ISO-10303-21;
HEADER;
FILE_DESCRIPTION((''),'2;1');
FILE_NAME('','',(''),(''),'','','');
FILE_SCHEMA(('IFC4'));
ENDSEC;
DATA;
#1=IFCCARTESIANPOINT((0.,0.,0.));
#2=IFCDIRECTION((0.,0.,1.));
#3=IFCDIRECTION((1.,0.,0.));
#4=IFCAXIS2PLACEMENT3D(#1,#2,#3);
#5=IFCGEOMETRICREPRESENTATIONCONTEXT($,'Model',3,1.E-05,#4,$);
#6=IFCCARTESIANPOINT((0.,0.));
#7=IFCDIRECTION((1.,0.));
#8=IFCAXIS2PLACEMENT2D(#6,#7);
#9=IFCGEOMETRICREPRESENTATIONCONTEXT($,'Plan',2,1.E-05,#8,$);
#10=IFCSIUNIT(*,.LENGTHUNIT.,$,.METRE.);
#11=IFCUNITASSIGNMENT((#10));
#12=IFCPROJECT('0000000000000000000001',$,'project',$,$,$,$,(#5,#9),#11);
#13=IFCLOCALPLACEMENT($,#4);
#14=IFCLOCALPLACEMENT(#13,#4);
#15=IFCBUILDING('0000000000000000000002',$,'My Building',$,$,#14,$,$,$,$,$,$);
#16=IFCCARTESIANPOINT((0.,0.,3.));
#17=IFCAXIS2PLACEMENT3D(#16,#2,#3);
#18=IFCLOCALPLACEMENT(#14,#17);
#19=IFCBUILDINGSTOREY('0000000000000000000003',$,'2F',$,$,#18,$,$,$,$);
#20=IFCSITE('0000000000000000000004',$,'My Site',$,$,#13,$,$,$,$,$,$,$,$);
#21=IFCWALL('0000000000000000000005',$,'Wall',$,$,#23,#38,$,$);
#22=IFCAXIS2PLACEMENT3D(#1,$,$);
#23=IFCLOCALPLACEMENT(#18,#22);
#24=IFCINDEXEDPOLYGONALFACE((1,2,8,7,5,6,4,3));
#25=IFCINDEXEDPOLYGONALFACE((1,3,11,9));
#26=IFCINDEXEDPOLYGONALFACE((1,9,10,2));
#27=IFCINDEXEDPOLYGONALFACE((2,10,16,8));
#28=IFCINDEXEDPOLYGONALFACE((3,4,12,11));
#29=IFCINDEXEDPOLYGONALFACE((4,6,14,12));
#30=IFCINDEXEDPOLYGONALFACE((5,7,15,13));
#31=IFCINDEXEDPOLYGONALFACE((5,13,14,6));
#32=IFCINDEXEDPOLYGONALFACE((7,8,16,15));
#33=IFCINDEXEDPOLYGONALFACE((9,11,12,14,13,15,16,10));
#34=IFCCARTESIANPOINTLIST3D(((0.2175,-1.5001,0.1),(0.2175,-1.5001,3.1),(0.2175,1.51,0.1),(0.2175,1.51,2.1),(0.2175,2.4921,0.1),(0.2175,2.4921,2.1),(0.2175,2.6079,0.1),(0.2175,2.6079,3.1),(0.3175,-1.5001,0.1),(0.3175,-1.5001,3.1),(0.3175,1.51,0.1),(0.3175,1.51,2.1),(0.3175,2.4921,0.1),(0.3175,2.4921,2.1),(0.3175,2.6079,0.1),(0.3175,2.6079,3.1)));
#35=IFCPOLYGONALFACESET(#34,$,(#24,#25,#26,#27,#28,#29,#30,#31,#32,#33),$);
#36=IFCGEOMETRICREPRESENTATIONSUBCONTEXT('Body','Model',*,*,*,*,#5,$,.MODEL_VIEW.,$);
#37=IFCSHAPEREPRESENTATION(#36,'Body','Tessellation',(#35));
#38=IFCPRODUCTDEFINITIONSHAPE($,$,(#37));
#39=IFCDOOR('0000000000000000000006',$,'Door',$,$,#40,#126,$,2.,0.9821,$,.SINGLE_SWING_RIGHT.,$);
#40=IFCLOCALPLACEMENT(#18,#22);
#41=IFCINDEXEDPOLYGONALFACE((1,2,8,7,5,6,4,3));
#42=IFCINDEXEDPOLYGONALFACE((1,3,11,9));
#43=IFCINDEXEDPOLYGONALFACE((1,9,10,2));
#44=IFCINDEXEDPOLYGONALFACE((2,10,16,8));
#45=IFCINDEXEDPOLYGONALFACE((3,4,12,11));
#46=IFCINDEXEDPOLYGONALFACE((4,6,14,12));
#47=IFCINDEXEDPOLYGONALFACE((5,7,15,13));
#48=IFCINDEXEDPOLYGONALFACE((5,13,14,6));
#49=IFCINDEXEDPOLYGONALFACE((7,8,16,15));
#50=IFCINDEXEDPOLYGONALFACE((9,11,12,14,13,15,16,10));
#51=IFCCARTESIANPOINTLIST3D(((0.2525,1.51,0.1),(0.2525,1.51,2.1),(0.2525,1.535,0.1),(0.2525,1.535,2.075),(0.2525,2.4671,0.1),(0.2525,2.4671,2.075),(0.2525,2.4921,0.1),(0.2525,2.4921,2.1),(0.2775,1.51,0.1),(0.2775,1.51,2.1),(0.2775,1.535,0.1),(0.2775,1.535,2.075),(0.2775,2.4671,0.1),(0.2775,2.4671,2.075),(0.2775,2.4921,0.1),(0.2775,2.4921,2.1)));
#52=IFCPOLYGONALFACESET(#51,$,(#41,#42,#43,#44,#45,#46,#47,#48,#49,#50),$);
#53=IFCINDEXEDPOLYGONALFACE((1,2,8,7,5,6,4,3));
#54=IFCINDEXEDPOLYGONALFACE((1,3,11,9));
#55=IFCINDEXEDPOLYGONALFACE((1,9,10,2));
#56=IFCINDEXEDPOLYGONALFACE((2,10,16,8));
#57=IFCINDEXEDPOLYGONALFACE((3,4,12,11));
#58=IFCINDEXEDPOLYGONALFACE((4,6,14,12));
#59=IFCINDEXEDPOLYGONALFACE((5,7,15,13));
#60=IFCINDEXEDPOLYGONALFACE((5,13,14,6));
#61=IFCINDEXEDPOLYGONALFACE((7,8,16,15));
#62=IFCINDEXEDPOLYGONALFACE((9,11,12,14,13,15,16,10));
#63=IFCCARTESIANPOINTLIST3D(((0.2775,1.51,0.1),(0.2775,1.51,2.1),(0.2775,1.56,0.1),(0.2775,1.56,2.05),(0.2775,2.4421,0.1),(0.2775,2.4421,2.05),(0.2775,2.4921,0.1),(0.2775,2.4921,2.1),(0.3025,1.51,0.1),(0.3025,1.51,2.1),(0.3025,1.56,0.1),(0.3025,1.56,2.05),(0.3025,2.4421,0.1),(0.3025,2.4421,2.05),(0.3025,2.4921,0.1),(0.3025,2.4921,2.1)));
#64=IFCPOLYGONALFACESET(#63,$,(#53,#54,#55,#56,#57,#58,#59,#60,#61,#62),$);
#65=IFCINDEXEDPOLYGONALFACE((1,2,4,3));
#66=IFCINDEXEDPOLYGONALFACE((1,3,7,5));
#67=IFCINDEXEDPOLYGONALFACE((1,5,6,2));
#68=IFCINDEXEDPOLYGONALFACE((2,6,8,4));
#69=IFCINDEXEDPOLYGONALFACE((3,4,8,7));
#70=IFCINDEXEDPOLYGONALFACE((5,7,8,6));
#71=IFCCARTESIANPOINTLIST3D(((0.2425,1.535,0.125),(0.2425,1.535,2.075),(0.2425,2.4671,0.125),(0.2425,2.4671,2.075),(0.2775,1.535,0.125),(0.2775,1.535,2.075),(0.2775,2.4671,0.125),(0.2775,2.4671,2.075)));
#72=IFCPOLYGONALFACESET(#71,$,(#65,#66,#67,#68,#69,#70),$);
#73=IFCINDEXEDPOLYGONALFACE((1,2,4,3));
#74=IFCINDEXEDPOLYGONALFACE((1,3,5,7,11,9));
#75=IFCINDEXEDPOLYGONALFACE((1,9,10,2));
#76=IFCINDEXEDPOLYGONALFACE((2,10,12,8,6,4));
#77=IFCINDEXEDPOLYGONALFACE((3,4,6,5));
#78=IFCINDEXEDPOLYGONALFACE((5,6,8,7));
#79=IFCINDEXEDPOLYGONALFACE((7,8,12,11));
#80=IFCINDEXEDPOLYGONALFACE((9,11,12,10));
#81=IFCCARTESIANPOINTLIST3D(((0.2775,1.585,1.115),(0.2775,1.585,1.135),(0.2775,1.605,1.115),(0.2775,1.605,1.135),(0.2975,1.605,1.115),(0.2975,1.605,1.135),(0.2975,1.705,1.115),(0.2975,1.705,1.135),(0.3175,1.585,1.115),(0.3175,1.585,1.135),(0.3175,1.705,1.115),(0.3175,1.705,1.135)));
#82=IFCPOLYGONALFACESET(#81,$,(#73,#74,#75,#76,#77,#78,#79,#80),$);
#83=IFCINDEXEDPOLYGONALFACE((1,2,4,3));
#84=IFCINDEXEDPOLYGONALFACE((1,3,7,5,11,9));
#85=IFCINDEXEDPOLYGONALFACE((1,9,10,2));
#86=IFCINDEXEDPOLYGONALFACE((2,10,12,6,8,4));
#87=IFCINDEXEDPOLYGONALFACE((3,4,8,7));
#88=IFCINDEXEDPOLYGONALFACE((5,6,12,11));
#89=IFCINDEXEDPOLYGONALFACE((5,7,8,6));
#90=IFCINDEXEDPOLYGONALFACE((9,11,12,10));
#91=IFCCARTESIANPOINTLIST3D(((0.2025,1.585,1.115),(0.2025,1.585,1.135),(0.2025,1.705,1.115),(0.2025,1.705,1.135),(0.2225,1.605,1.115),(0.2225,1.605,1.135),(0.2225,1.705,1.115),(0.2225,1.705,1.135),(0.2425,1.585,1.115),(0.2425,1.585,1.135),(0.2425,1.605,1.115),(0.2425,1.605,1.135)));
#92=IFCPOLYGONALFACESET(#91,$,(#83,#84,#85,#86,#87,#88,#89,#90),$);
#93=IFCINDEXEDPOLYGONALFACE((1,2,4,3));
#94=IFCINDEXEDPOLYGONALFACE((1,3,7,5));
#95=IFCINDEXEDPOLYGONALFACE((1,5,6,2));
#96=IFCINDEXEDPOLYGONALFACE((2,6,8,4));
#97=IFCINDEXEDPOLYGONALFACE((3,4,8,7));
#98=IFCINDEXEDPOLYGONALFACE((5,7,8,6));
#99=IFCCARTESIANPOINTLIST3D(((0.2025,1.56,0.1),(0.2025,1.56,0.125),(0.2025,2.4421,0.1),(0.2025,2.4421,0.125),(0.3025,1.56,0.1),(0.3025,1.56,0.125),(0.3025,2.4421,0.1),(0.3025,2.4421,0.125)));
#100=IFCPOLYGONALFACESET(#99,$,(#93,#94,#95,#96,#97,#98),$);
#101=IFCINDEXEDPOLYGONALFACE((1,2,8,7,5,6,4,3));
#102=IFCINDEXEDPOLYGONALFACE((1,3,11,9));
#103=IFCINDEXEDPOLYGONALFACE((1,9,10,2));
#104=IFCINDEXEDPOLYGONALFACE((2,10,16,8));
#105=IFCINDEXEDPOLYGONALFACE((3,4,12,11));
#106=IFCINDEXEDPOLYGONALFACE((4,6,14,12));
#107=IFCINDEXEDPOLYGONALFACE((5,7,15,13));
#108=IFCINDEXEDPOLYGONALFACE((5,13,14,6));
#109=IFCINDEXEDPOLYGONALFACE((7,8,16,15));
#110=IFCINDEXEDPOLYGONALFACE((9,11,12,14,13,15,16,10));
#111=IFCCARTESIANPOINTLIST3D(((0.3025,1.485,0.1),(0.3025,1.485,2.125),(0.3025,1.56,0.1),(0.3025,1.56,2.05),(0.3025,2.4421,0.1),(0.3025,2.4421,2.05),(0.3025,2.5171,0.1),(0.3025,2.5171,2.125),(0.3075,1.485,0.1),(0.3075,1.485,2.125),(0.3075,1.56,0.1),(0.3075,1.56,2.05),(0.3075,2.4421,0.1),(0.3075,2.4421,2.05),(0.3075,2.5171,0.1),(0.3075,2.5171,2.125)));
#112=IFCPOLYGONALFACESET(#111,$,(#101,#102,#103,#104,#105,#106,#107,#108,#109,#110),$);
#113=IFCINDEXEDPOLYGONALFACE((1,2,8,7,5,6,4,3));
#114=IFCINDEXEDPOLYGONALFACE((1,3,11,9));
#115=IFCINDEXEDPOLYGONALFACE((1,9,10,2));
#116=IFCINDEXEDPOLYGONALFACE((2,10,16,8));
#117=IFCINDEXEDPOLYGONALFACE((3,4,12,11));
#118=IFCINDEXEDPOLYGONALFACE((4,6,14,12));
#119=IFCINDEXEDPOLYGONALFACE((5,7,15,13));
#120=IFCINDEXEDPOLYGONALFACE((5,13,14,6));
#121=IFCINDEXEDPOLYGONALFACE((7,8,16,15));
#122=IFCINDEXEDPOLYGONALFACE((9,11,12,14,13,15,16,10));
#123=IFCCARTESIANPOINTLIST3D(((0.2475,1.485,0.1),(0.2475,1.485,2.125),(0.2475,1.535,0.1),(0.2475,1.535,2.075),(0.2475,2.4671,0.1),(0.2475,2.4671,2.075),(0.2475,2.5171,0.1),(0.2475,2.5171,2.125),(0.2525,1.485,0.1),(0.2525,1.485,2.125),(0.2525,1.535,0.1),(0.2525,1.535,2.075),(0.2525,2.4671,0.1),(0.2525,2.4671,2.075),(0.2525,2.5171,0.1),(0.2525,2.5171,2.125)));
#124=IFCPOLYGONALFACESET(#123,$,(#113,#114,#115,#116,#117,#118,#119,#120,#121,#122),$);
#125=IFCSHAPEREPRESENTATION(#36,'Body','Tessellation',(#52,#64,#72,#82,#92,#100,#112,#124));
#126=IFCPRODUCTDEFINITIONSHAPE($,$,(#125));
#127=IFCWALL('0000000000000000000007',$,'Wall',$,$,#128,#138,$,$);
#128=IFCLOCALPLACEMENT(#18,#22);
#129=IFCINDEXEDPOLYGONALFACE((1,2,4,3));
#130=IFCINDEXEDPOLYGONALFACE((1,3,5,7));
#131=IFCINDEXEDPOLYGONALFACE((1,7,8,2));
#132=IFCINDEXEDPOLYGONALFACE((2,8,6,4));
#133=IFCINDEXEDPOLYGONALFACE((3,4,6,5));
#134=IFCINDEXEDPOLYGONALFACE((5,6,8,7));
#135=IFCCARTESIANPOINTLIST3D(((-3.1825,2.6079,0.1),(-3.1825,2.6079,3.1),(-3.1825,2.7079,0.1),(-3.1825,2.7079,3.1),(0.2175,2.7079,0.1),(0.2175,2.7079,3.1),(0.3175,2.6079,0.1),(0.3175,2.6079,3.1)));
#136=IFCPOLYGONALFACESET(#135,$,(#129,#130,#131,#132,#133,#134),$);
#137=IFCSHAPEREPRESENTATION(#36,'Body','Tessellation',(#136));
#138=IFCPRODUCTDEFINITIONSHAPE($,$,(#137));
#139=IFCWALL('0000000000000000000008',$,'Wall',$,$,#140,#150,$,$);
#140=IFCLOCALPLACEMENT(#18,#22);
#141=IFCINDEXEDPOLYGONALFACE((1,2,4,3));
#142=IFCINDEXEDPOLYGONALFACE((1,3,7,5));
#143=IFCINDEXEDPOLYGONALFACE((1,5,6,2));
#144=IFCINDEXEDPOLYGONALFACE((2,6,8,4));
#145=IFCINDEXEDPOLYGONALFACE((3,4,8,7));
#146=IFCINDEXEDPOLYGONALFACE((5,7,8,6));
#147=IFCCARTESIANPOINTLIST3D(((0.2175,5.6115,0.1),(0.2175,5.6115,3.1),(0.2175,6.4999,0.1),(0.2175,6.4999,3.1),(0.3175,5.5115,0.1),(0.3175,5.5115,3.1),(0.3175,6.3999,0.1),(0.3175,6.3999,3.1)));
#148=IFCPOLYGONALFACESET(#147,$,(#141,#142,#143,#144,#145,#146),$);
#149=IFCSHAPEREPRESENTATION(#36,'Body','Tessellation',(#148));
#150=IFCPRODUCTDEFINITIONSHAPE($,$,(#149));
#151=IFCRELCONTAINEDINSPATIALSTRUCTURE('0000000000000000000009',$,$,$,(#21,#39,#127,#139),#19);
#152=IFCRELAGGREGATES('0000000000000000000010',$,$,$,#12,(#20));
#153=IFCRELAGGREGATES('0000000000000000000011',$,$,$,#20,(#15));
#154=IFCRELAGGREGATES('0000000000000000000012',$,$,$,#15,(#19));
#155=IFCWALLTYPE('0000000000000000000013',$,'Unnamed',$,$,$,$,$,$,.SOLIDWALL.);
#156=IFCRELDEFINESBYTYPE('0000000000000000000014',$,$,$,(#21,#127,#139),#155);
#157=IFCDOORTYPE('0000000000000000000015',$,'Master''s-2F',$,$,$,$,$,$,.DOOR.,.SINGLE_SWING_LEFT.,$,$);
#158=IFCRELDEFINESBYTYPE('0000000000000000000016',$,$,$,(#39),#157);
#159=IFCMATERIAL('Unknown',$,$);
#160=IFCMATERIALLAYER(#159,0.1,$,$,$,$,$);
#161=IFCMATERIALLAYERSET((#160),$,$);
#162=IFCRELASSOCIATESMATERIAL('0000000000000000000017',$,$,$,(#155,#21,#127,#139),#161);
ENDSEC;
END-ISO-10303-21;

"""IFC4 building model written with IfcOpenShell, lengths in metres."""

from ifc_helpers import new_model, entity, si_unit, frame, origin_with_axes, origin_2d_with_axis, place, context, subcontext, project, spatial, line, indexed_curve, outline, extrude, shape, source, transform, mapped, material, layer, layer_set, layer_usage, type_object, type_shapes, element, fill, save


model = new_model("IFC4")

# Units and contexts
model_context = context("Model", 3, precision=1e-05, world=origin_with_axes())
plan_context = context("Plan", 2, precision=1e-05, world=origin_2d_with_axis())
body_context_1 = subcontext(model_context, "Body", "Model", "MODEL_VIEW")
body_context_2 = subcontext(plan_context, "Body", "Plan", "PLAN_VIEW")
ifc_project = project(units=[si_unit("LENGTHUNIT", "METRE")], contexts=[model_context, plan_context])

# Site, building, storey
site_placement = place(None, origin_with_axes())
site = spatial("IfcSite", under=ifc_project, at=site_placement, Name="My Site")
building_placement = place(site_placement, origin_with_axes())
building = spatial("IfcBuilding", under=site, at=building_placement, Name="My Building")
storey_placement = place(building_placement, frame((0.0, 0.0, 3.0), z_axis=(0.0, 0.0, 1.0), x_axis=(1.0, 0.0, 0.0)))
storey = spatial("IfcBuildingStorey", under=building, at=storey_placement, Name="2F")

# Shared definitions
ifc_material = material(Name="Unknown")

# Shared definitions
ifc_layer_1 = layer(ifc_material, 0.1)
ifc_layer_set_1 = layer_set([ifc_layer_1])
wall_type = type_object("IfcWallType", Name="Unnamed", PredefinedType="SOLIDWALL", material=ifc_layer_set_1)

# Wall, opening, door
ifc_layer_usage_1 = layer_usage(ifc_layer_set_1, "AXIS2", "POSITIVE", 0.0)
wall_1_placement = place(storey_placement, frame((0.2175, 2.7079, 0.1), z_axis=(0.0, 0.0, 1.0), x_axis=(0.0, -1.0, 0.0)))
wall_1 = element("IfcWall", 1, at=wall_1_placement, inside=storey, type_object=wall_type, material=ifc_layer_usage_1, Name="Wall", context=body_context_1, shape_type="SweptSolid", body=[
    extrude(outline(indexed_curve([(0.1, 0.0), (0.1, 0.1), (4.2079, 0.1), (4.2079, 0.0)], segments=[line(1, 2, 3, 4, 1)])), origin_with_axes(), (0.0, 0.0, 1.0), 3.0),
])
shared_shape_1 = source(origin_with_axes(), body_context_1, "Body", "SweptSolid", [
    extrude(outline(indexed_curve([(0.0, 0.0), (0.9821, 0.0), (0.9821, 2.0), (0.0, 2.0)], segments=[line(1, 2, 3, 4, 1)])), frame((0.0, -0.6, 0.0), z_axis=(0.0, -1.0, 0.0), x_axis=(1.0, 0.0, 0.0)), (0.0, 0.0, -1.0), 1.2),
])
opening_1_placement = place(wall_1_placement, frame((1.1978, 0.085, 0.0), z_axis=(0.0, 0.0, 1.0), x_axis=(-1.0, 0.0, 0.0)))
opening_1 = element("IfcOpeningElement", 2, at=opening_1_placement, cuts=wall_1, PredefinedType="OPENING", context=body_context_1, shape_type="MappedRepresentation", body=[
    mapped(shared_shape_1, transform((0.0, 0.0, 0.0), x_axis=(1.0, 0.0, 0.0), y_axis=(0.0, 1.0, 0.0), z_axis=(0.0, 0.0, 1.0), scale=1.0)),
])
door_type_1 = type_object("IfcDoorType", Name="Master's-2F", OperationType="SINGLE_SWING_LEFT", PredefinedType="DOOR")
shared_shape_2 = source(origin_with_axes(), body_context_1, "Body", "SweptSolid", [
    extrude(outline(indexed_curve([(0.0, 0.0), (0.0, 2.0), (0.9821, 2.0), (0.9821, 0.0), (0.9571, 0.0), (0.9571, 1.975), (0.025, 1.975), (0.025, 0.0)], segments=[line(1, 2, 3, 4, 5, 6, 7, 8, 1)])), frame((0.0, 0.025, 0.0), z_axis=(0.0, -1.0, 0.0), x_axis=(1.0, 0.0, 0.0)), (0.0, 0.0, -1.0), 0.025),
    extrude(outline(indexed_curve([(0.0, 0.0), (0.0, 2.0), (0.9821, 2.0), (0.9821, 0.0), (0.9321, 0.0), (0.9321, 1.95), (0.05, 1.95), (0.05, 0.0)], segments=[line(1, 2, 3, 4, 5, 6, 7, 8, 1)])), frame((0.0, 0.0, 0.0), z_axis=(0.0, -1.0, 0.0), x_axis=(1.0, 0.0, 0.0)), (0.0, 0.0, -1.0), 0.025),
    extrude(outline(indexed_curve([(0.0, 0.0), (0.9321, 0.0), (0.9321, 0.035), (0.0, 0.035)], segments=[line(1, 2, 3, 4, 1)])), frame((0.025, 0.025, 0.025), z_axis=(0.0, 0.0, 1.0), x_axis=(1.0, 0.0, 0.0)), (0.0, 0.0, 1.0), 1.95),
    extrude(outline(indexed_curve([(0.0, 0.0), (0.0, -0.04), (0.12, -0.04), (0.12, -0.02), (0.02, -0.02), (0.02, 0.0)], segments=[line(1, 2, 3, 4, 5, 6, 1)])), frame((0.075, 0.025, 1.015), z_axis=(0.0, 0.0, 1.0), x_axis=(1.0, 0.0, 0.0)), (0.0, 0.0, 1.0), 0.02),
    extrude(outline(indexed_curve([(0.0, 0.0), (0.0, 0.04), (0.12, 0.04), (0.12, 0.02), (0.02, 0.02), (0.02, 0.0)], segments=[line(1, 2, 3, 4, 5, 6, 1)])), frame((0.075, 0.06, 1.015), z_axis=(0.0, 0.0, 1.0), x_axis=(1.0, 0.0, 0.0)), (0.0, 0.0, 1.0), 0.02),
    extrude(outline(indexed_curve([(0.0, 0.0), (0.8821, 0.0), (0.8821, 0.1), (0.0, 0.1)], segments=[line(1, 2, 3, 4, 1)])), frame((0.05, 0.0, 0.0), z_axis=(0.0, 0.0, 1.0), x_axis=(1.0, 0.0, 0.0)), (0.0, 0.0, 1.0), 0.025),
    extrude(outline(indexed_curve([(0.0, 0.0), (0.0, 2.025), (1.0321, 2.025), (1.0321, 0.0), (0.9571, 0.0), (0.9571, 1.95), (0.075, 1.95), (0.075, 0.0)], segments=[line(1, 2, 3, 4, 5, 6, 7, 8, 1)])), frame((-0.025, -0.005, 0.0), z_axis=(0.0, -1.0, 0.0), x_axis=(1.0, 0.0, 0.0)), (0.0, 0.0, -1.0), 0.005),
    extrude(outline(indexed_curve([(0.0, 0.0), (0.0, 2.025), (1.0321, 2.025), (1.0321, 0.0), (0.9821, 0.0), (0.9821, 1.975), (0.05, 1.975), (0.05, 0.0)], segments=[line(1, 2, 3, 4, 5, 6, 7, 8, 1)])), frame((-0.025, 0.05, 0.0), z_axis=(0.0, -1.0, 0.0), x_axis=(1.0, 0.0, 0.0)), (0.0, 0.0, -1.0), 0.005),
])
shared_shape_3 = source(origin_with_axes(), body_context_2, "Body", "Curve2D", [
    entity("IfcIndexedPolyCurve", entity("IfcCartesianPointList2D", [[0.0, 0.0], [0.0, 0.05], [0.025, 0.05], [0.025, 0.025], [0.05, 0.025], [0.05, 0.0]]), [entity("IfcLineIndex", [1, 2, 3, 4, 5, 6, 1])]),
    entity("IfcIndexedPolyCurve", entity("IfcCartesianPointList2D", [[0.9821, 0.0], [0.9821, 0.05], [0.9571, 0.05], [0.9571, 0.025], [0.9321, 0.025], [0.9321, 0.0]]), [entity("IfcLineIndex", [1, 2, 3, 4, 5, 6, 1])]),
    entity("IfcTrimmedCurve", entity("IfcEllipse", entity("IfcAxis2Placement2D", entity("IfcCartesianPoint", [0.9221, 0.05]), entity("IfcDirection", [1.0, 0.0])), 0.8971, 0.9321), [entity("IfcCartesianPoint", [0.9221, 0.9821])], [entity("IfcCartesianPoint", [0.025, 0.05])], True, "CARTESIAN"),
    entity("IfcIndexedPolyCurve", entity("IfcCartesianPointList2D", [[0.9571, 0.05], [0.9221, 0.05], [0.9221, 0.9821], [0.9571, 0.9821]]), [entity("IfcLineIndex", [1, 2, 3, 4, 1])]),
])
type_shapes(door_type_1, [shared_shape_2, shared_shape_3])
door_1_placement = place(opening_1_placement, frame((0.0, 0.0, 0.0), z_axis=(0.0, 0.0, 1.0), x_axis=(1.0, 0.0, 0.0)))
door_1 = element("IfcDoor", 3, at=door_1_placement, inside=storey, type_object=door_type_1, Name="Door", OperationType="SINGLE_SWING_RIGHT", OverallHeight=2.0, OverallWidth=0.9821, shapes=[
    shape(body_context_1, "Body", "MappedRepresentation", [mapped(shared_shape_2, transform((0.0, 0.0, 0.0), x_axis=(1.0, 0.0, 0.0), y_axis=(0.0, 1.0, 0.0), z_axis=(0.0, 0.0, 1.0), scale=1.0))]),
    shape(body_context_2, "Body", "MappedRepresentation", [mapped(shared_shape_3, transform((0.0, 0.0, 0.0), x_axis=(1.0, 0.0, 0.0), y_axis=(0.0, 1.0, 0.0), z_axis=(0.0, 0.0, 1.0), scale=1.0))]),
])
fill(opening_1, door_1)

# Walls
ifc_layer_usage_2 = layer_usage(ifc_layer_set_1, "AXIS2", "POSITIVE", 0.0)
wall_2_placement = place(storey_placement, frame((0.3175, 2.7079, 0.1), z_axis=(0.0, 0.0, 1.0), x_axis=(-1.0, 0.0, 0.0)))
element("IfcWall", 4, at=wall_2_placement, inside=storey, type_object=wall_type, material=ifc_layer_usage_2, Name="Wall", context=body_context_1, shape_type="SweptSolid", body=[
    extrude(outline(indexed_curve([(0.1, 0.0), (0.0, 0.1), (3.5, 0.1), (3.5, 0.0)], segments=[line(1, 2, 3, 4, 1)])), origin_with_axes(), (0.0, 0.0, 1.0), 3.0),
])
ifc_layer_usage_3 = layer_usage(ifc_layer_set_1, "AXIS2", "POSITIVE", 0.0)
wall_3_placement = place(storey_placement, frame((0.3175, 5.5115, 0.1), z_axis=(0.0, 0.0, 1.0), x_axis=(0.0, 1.0, 0.0)))
element("IfcWall", 5, at=wall_3_placement, inside=storey, type_object=wall_type, material=ifc_layer_usage_3, Name="Wall", context=body_context_1, shape_type="SweptSolid", body=[
    extrude(outline(indexed_curve([(0.0, 0.0), (0.1, 0.1), (0.9884, 0.1), (0.8884, 0.0)], segments=[line(1, 2, 3, 4, 1)])), origin_with_axes(), (0.0, 0.0, 1.0), 3.0),
])

save(model, "model.ifc")
